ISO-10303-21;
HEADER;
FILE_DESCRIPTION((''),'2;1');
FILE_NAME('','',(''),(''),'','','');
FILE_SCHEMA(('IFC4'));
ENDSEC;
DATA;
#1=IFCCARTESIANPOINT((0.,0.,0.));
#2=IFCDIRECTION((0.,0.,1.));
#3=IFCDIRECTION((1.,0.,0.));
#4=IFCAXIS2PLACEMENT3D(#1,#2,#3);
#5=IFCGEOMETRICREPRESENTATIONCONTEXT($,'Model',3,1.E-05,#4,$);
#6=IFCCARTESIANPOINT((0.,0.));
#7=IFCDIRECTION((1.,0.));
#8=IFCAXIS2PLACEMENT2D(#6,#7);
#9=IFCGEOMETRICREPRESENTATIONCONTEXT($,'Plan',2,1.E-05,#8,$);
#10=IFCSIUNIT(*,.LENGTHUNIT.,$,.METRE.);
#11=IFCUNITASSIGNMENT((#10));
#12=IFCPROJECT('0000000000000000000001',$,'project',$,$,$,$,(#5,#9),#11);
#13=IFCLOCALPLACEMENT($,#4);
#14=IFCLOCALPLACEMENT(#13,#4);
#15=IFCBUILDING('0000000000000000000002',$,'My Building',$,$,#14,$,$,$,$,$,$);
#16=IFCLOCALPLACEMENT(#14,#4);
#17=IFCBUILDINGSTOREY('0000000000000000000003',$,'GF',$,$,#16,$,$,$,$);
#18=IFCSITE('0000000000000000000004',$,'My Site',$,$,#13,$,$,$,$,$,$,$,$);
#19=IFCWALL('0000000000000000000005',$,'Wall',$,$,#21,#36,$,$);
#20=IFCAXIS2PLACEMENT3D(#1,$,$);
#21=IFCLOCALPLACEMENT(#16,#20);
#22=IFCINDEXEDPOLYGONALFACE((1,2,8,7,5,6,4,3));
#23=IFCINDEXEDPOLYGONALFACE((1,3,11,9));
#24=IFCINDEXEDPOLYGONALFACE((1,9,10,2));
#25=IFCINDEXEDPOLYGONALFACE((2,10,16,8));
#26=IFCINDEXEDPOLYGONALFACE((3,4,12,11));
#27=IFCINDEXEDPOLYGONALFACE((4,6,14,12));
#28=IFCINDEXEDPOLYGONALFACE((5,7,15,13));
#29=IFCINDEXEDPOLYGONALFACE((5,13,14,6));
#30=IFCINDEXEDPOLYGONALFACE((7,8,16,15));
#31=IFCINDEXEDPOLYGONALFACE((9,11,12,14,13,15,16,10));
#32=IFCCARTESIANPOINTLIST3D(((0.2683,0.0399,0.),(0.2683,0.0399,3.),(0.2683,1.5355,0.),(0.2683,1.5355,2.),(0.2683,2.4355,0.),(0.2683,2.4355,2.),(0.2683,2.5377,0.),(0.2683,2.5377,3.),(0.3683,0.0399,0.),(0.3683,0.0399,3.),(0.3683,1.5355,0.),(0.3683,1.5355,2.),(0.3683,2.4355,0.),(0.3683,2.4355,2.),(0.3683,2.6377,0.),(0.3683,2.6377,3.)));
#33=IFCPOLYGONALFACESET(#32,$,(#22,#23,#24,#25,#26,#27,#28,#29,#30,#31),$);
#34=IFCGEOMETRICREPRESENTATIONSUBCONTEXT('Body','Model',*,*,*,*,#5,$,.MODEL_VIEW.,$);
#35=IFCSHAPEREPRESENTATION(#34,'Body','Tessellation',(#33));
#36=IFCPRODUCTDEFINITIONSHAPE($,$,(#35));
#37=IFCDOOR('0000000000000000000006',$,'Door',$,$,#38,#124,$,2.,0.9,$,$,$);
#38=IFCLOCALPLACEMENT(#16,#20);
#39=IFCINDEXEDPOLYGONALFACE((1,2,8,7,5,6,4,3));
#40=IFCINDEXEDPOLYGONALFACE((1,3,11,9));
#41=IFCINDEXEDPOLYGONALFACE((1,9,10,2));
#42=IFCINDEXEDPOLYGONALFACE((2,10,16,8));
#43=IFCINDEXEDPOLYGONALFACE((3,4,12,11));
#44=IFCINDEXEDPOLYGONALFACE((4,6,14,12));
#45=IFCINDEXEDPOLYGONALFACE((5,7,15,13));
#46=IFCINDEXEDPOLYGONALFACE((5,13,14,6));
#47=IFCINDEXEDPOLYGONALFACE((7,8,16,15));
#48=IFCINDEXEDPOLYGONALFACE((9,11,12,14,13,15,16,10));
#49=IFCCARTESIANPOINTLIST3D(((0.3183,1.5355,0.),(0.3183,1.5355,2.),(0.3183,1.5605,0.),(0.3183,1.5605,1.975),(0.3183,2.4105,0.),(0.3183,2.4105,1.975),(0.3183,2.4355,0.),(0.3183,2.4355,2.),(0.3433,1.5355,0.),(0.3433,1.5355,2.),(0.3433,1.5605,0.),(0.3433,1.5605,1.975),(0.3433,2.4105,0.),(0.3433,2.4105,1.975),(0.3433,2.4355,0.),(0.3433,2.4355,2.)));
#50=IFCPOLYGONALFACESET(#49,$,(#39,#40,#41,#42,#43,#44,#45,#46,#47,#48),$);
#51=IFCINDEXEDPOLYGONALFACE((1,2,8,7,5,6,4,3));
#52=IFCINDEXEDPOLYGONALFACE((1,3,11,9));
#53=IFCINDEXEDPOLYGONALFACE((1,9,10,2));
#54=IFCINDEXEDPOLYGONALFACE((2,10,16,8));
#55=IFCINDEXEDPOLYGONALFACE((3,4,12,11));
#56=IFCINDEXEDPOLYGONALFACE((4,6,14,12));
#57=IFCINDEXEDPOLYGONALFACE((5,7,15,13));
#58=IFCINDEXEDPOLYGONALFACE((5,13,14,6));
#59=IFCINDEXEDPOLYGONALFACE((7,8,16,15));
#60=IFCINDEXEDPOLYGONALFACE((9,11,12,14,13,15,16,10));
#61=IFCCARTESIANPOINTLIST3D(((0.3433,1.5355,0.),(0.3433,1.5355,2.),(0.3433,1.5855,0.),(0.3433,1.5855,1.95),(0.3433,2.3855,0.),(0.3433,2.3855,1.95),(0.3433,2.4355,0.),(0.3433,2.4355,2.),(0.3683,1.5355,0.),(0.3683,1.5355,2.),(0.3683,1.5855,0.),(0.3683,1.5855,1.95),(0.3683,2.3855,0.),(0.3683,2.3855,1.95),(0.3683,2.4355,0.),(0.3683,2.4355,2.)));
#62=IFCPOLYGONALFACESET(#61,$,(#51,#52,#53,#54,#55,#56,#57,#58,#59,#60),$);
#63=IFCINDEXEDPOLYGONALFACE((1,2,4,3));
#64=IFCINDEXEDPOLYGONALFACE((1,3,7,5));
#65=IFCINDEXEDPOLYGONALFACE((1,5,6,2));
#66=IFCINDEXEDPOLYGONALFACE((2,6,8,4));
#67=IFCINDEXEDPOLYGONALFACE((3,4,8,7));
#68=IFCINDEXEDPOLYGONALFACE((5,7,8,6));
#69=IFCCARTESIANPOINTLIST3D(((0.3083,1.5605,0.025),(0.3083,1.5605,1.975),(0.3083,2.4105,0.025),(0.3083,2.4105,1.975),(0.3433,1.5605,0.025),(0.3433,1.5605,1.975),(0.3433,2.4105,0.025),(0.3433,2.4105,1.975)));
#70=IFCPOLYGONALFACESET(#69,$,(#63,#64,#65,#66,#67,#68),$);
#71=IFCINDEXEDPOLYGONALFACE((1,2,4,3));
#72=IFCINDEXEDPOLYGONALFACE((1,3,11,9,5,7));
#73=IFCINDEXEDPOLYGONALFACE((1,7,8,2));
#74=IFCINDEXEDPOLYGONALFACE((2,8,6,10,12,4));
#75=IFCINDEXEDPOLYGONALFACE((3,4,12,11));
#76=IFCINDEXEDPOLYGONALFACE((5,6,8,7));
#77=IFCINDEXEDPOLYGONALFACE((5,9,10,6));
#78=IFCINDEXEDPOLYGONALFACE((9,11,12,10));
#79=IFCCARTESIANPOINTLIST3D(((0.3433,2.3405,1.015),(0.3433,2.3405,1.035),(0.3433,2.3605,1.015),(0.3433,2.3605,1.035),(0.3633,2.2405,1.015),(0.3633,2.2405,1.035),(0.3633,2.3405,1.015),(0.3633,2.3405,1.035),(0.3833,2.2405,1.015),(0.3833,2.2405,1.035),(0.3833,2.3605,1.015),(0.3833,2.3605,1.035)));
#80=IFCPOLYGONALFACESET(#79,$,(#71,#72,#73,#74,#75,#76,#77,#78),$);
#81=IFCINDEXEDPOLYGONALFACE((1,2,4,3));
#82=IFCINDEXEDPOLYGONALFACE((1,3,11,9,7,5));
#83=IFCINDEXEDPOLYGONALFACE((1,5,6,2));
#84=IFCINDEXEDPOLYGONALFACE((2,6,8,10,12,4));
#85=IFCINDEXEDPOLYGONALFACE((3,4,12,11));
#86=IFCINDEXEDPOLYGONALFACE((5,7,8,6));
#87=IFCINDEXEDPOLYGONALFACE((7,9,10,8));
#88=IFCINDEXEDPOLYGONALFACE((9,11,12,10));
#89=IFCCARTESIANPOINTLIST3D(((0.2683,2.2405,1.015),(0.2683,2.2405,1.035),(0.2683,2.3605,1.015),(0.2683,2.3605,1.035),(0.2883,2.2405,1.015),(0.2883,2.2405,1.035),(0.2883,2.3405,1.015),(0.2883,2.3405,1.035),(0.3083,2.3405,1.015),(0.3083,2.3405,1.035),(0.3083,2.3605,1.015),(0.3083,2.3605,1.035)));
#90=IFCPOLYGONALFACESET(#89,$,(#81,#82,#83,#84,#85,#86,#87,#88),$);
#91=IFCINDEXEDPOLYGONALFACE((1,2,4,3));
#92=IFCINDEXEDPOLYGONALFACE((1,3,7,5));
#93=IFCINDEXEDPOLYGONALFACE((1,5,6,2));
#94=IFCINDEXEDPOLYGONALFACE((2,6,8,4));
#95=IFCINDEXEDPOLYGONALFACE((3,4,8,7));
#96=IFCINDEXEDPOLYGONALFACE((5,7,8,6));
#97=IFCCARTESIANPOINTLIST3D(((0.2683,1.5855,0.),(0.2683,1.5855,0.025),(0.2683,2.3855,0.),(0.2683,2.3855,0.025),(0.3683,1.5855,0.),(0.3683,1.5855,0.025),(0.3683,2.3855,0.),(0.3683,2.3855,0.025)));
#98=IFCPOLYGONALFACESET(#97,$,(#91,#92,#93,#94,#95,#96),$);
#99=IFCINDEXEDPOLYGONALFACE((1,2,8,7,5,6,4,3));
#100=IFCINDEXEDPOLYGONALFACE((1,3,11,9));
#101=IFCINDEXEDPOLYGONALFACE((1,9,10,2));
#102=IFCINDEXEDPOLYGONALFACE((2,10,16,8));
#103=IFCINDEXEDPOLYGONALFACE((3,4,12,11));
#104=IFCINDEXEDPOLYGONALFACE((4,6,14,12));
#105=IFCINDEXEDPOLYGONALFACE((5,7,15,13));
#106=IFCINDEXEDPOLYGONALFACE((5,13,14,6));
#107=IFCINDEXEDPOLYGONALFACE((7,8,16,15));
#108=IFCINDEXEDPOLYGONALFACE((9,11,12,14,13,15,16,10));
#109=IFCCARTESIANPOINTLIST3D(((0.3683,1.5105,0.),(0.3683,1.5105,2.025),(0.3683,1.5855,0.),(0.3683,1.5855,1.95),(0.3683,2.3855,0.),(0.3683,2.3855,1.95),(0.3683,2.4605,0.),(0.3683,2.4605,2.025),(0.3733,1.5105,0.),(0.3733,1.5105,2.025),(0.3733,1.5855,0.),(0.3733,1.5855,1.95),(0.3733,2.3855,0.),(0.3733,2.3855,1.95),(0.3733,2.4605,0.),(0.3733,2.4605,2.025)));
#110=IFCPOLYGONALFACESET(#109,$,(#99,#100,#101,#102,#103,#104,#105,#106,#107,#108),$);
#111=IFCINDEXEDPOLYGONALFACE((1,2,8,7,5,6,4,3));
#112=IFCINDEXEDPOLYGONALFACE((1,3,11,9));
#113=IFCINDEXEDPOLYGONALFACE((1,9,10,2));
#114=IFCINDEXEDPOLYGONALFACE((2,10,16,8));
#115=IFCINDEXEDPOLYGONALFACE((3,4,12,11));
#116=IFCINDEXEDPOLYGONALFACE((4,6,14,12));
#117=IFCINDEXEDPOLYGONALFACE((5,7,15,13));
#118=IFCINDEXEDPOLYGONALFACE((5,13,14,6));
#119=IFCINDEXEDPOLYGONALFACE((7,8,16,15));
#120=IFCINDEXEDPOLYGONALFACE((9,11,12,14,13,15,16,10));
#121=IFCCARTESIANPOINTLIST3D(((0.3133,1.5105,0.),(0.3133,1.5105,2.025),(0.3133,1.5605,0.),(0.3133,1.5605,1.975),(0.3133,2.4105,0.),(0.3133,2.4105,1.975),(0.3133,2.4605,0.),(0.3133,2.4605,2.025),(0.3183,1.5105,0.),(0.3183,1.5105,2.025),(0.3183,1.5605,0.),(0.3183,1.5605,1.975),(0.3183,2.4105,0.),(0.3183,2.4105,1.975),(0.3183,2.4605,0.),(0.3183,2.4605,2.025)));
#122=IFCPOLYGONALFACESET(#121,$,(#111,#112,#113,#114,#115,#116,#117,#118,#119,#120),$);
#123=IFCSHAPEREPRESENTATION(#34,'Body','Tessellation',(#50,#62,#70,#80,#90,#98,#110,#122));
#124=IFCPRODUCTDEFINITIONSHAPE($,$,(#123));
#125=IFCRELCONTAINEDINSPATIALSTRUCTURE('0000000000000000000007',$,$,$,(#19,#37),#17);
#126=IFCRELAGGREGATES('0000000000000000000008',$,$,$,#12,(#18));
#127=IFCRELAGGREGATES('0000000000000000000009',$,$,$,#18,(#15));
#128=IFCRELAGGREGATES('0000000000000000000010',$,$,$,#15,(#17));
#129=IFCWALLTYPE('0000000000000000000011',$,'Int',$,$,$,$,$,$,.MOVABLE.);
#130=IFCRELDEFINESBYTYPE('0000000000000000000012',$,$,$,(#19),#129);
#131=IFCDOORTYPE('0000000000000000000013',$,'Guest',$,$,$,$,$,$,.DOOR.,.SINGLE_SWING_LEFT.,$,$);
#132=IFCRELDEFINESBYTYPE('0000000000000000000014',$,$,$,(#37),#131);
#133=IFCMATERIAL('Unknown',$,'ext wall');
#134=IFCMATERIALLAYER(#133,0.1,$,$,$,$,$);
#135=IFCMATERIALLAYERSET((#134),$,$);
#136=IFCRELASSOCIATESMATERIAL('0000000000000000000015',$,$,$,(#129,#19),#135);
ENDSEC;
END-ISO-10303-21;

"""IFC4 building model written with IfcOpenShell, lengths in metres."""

from ifc_helpers import new_model, entity, si_unit, frame, origin_with_axes, origin_2d_with_axis, place, context, subcontext, project, spatial, line, indexed_curve, outline, extrude, shape, source, transform, mapped, material, layer, layer_set, layer_usage, type_object, type_shapes, element, fill, save


model = new_model("IFC4")

# Units and contexts
model_context = context("Model", 3, precision=1e-05, world=origin_with_axes())
plan_context = context("Plan", 2, precision=1e-05, world=origin_2d_with_axis())
body_context_1 = subcontext(model_context, "Body", "Model", "MODEL_VIEW")
body_context_2 = subcontext(plan_context, "Body", "Plan", "PLAN_VIEW")
ifc_project = project(units=[si_unit("LENGTHUNIT", "METRE")], contexts=[model_context, plan_context])

# Site, building, storey
site_placement = place(None, origin_with_axes())
site = spatial("IfcSite", under=ifc_project, at=site_placement, Name="My Site")
building_placement = place(site_placement, origin_with_axes())
building = spatial("IfcBuilding", under=site, at=building_placement, Name="My Building")
storey_placement = place(building_placement, origin_with_axes())
storey = spatial("IfcBuildingStorey", under=building, at=storey_placement, Name="GF")

# Shared definitions
ifc_material = material(Name="Unknown", Category="ext wall")

# Shared definitions
ifc_layer_1 = layer(ifc_material, 0.1)
ifc_layer_set_1 = layer_set([ifc_layer_1])
wall_type_1 = type_object("IfcWallType", Name="Int", PredefinedType="MOVABLE", material=ifc_layer_set_1)

# Wall, opening, door
ifc_layer_usage_1 = layer_usage(ifc_layer_set_1, "AXIS2", "POSITIVE", 0.0)
wall_1_placement = place(storey_placement, frame((0.2683, 2.5377, 0.0), z_axis=(0.0, 0.0, 1.0), x_axis=(0.0, -1.0, 0.0)))
wall_1 = element("IfcWall", 1, at=wall_1_placement, inside=storey, type_object=wall_type_1, material=ifc_layer_usage_1, Name="Wall", context=body_context_1, shape_type="SweptSolid", body=[
    extrude(outline(indexed_curve([(0.0, 0.0), (-0.1, 0.1), (2.4978, 0.1), (2.4978, 0.0)], segments=[line(1, 2, 3, 4, 1)])), origin_with_axes(), (0.0, 0.0, 1.0), 3.0),
])
shared_shape_1 = source(origin_with_axes(), body_context_1, "Body", "SweptSolid", [
    extrude(outline(indexed_curve([(0.0, 0.0), (0.9, 0.0), (0.9, 2.0), (0.0, 2.0)], segments=[line(1, 2, 3, 4, 1)])), frame((0.0, -0.6, 0.0), z_axis=(0.0, -1.0, 0.0), x_axis=(1.0, 0.0, 0.0)), (0.0, 0.0, -1.0), 1.2),
])
opening_1_placement = place(wall_1_placement, frame((1.0022, 0.1, 0.0), z_axis=(0.0, 0.0, 1.0), x_axis=(-1.0, 0.0, 0.0)))
opening_1 = element("IfcOpeningElement", 2, at=opening_1_placement, cuts=wall_1, PredefinedType="OPENING", context=body_context_1, shape_type="MappedRepresentation", body=[
    mapped(shared_shape_1, transform((0.0, 0.0, 0.0), x_axis=(1.0, 0.0, 0.0), y_axis=(0.0, 1.0, 0.0), z_axis=(0.0, 0.0, 1.0), scale=1.0)),
])
door_type_1 = type_object("IfcDoorType", Name="Guest", OperationType="SINGLE_SWING_LEFT", PredefinedType="DOOR")
shared_shape_2 = source(origin_with_axes(), body_context_1, "Body", "SweptSolid", [
    extrude(outline(indexed_curve([(0.0, 0.0), (0.0, 2.0), (0.9, 2.0), (0.9, 0.0), (0.875, 0.0), (0.875, 1.975), (0.025, 1.975), (0.025, 0.0)], segments=[line(1, 2, 3, 4, 5, 6, 7, 8, 1)])), frame((0.0, 0.025, 0.0), z_axis=(0.0, -1.0, 0.0), x_axis=(1.0, 0.0, 0.0)), (0.0, 0.0, -1.0), 0.025),
    extrude(outline(indexed_curve([(0.0, 0.0), (0.0, 2.0), (0.9, 2.0), (0.9, 0.0), (0.85, 0.0), (0.85, 1.95), (0.05, 1.95), (0.05, 0.0)], segments=[line(1, 2, 3, 4, 5, 6, 7, 8, 1)])), frame((0.0, 0.0, 0.0), z_axis=(0.0, -1.0, 0.0), x_axis=(1.0, 0.0, 0.0)), (0.0, 0.0, -1.0), 0.025),
    extrude(outline(indexed_curve([(0.0, 0.0), (0.85, 0.0), (0.85, 0.035), (0.0, 0.035)], segments=[line(1, 2, 3, 4, 1)])), frame((0.025, 0.025, 0.025), z_axis=(0.0, 0.0, 1.0), x_axis=(1.0, 0.0, 0.0)), (0.0, 0.0, 1.0), 1.95),
    extrude(outline(indexed_curve([(0.0, 0.0), (0.0, -0.04), (-0.12, -0.04), (-0.12, -0.02), (-0.02, -0.02), (-0.02, 0.0)], segments=[line(1, 2, 3, 4, 5, 6, 1)])), frame((0.825, 0.025, 1.015), z_axis=(0.0, 0.0, 1.0), x_axis=(1.0, 0.0, 0.0)), (0.0, 0.0, 1.0), 0.02),
    extrude(outline(indexed_curve([(0.0, 0.0), (0.0, 0.04), (-0.12, 0.04), (-0.12, 0.02), (-0.02, 0.02), (-0.02, 0.0)], segments=[line(1, 2, 3, 4, 5, 6, 1)])), frame((0.825, 0.06, 1.015), z_axis=(0.0, 0.0, 1.0), x_axis=(1.0, 0.0, 0.0)), (0.0, 0.0, 1.0), 0.02),
    extrude(outline(indexed_curve([(0.0, 0.0), (0.8, 0.0), (0.8, 0.1), (0.0, 0.1)], segments=[line(1, 2, 3, 4, 1)])), frame((0.05, 0.0, 0.0), z_axis=(0.0, 0.0, 1.0), x_axis=(1.0, 0.0, 0.0)), (0.0, 0.0, 1.0), 0.025),
    extrude(outline(indexed_curve([(0.0, 0.0), (0.0, 2.025), (0.95, 2.025), (0.95, 0.0), (0.875, 0.0), (0.875, 1.95), (0.075, 1.95), (0.075, 0.0)], segments=[line(1, 2, 3, 4, 5, 6, 7, 8, 1)])), frame((-0.025, -0.005, 0.0), z_axis=(0.0, -1.0, 0.0), x_axis=(1.0, 0.0, 0.0)), (0.0, 0.0, -1.0), 0.005),
    extrude(outline(indexed_curve([(0.0, 0.0), (0.0, 2.025), (0.95, 2.025), (0.95, 0.0), (0.9, 0.0), (0.9, 1.975), (0.05, 1.975), (0.05, 0.0)], segments=[line(1, 2, 3, 4, 5, 6, 7, 8, 1)])), frame((-0.025, 0.05, 0.0), z_axis=(0.0, -1.0, 0.0), x_axis=(1.0, 0.0, 0.0)), (0.0, 0.0, -1.0), 0.005),
])
shared_shape_3 = source(origin_with_axes(), body_context_2, "Body", "Curve2D", [
    entity("IfcIndexedPolyCurve", entity("IfcCartesianPointList2D", [[0.0, 0.0], [0.0, 0.05], [0.025, 0.05], [0.025, 0.025], [0.05, 0.025], [0.05, 0.0]]), [entity("IfcLineIndex", [1, 2, 3, 4, 5, 6, 1])]),
    entity("IfcIndexedPolyCurve", entity("IfcCartesianPointList2D", [[0.9, 0.0], [0.9, 0.05], [0.875, 0.05], [0.875, 0.025], [0.85, 0.025], [0.85, 0.0]]), [entity("IfcLineIndex", [1, 2, 3, 4, 5, 6, 1])]),
    entity("IfcTrimmedCurve", entity("IfcEllipse", entity("IfcAxis2Placement2D", entity("IfcCartesianPoint", [0.06, 0.05]), entity("IfcDirection", [1.0, 0.0])), 0.815, 0.85), [entity("IfcCartesianPoint", [0.875, 0.05])], [entity("IfcCartesianPoint", [0.06, 0.9])], True, "CARTESIAN"),
    entity("IfcIndexedPolyCurve", entity("IfcCartesianPointList2D", [[0.025, 0.05], [0.06, 0.05], [0.06, 0.9], [0.025, 0.9]]), [entity("IfcLineIndex", [1, 2, 3, 4, 1])]),
])
type_shapes(door_type_1, [shared_shape_2, shared_shape_3])
door_1_placement = place(opening_1_placement, frame((0.0, 0.0, 0.0), z_axis=(0.0, 0.0, 1.0), x_axis=(1.0, 0.0, 0.0)))
door_1 = element("IfcDoor", 3, at=door_1_placement, inside=storey, type_object=door_type_1, Name="Door", OverallHeight=2.0, OverallWidth=0.9, shapes=[
    shape(body_context_1, "Body", "MappedRepresentation", [mapped(shared_shape_2, transform((0.0, 0.0, 0.0), x_axis=(1.0, 0.0, 0.0), y_axis=(0.0, 1.0, 0.0), z_axis=(0.0, 0.0, 1.0), scale=1.0))]),
    shape(body_context_2, "Body", "MappedRepresentation", [mapped(shared_shape_3, transform((0.0, 0.0, 0.0), x_axis=(1.0, 0.0, 0.0), y_axis=(0.0, 1.0, 0.0), z_axis=(0.0, 0.0, 1.0), scale=1.0))]),
])
fill(opening_1, door_1)

save(model, "model.ifc")
